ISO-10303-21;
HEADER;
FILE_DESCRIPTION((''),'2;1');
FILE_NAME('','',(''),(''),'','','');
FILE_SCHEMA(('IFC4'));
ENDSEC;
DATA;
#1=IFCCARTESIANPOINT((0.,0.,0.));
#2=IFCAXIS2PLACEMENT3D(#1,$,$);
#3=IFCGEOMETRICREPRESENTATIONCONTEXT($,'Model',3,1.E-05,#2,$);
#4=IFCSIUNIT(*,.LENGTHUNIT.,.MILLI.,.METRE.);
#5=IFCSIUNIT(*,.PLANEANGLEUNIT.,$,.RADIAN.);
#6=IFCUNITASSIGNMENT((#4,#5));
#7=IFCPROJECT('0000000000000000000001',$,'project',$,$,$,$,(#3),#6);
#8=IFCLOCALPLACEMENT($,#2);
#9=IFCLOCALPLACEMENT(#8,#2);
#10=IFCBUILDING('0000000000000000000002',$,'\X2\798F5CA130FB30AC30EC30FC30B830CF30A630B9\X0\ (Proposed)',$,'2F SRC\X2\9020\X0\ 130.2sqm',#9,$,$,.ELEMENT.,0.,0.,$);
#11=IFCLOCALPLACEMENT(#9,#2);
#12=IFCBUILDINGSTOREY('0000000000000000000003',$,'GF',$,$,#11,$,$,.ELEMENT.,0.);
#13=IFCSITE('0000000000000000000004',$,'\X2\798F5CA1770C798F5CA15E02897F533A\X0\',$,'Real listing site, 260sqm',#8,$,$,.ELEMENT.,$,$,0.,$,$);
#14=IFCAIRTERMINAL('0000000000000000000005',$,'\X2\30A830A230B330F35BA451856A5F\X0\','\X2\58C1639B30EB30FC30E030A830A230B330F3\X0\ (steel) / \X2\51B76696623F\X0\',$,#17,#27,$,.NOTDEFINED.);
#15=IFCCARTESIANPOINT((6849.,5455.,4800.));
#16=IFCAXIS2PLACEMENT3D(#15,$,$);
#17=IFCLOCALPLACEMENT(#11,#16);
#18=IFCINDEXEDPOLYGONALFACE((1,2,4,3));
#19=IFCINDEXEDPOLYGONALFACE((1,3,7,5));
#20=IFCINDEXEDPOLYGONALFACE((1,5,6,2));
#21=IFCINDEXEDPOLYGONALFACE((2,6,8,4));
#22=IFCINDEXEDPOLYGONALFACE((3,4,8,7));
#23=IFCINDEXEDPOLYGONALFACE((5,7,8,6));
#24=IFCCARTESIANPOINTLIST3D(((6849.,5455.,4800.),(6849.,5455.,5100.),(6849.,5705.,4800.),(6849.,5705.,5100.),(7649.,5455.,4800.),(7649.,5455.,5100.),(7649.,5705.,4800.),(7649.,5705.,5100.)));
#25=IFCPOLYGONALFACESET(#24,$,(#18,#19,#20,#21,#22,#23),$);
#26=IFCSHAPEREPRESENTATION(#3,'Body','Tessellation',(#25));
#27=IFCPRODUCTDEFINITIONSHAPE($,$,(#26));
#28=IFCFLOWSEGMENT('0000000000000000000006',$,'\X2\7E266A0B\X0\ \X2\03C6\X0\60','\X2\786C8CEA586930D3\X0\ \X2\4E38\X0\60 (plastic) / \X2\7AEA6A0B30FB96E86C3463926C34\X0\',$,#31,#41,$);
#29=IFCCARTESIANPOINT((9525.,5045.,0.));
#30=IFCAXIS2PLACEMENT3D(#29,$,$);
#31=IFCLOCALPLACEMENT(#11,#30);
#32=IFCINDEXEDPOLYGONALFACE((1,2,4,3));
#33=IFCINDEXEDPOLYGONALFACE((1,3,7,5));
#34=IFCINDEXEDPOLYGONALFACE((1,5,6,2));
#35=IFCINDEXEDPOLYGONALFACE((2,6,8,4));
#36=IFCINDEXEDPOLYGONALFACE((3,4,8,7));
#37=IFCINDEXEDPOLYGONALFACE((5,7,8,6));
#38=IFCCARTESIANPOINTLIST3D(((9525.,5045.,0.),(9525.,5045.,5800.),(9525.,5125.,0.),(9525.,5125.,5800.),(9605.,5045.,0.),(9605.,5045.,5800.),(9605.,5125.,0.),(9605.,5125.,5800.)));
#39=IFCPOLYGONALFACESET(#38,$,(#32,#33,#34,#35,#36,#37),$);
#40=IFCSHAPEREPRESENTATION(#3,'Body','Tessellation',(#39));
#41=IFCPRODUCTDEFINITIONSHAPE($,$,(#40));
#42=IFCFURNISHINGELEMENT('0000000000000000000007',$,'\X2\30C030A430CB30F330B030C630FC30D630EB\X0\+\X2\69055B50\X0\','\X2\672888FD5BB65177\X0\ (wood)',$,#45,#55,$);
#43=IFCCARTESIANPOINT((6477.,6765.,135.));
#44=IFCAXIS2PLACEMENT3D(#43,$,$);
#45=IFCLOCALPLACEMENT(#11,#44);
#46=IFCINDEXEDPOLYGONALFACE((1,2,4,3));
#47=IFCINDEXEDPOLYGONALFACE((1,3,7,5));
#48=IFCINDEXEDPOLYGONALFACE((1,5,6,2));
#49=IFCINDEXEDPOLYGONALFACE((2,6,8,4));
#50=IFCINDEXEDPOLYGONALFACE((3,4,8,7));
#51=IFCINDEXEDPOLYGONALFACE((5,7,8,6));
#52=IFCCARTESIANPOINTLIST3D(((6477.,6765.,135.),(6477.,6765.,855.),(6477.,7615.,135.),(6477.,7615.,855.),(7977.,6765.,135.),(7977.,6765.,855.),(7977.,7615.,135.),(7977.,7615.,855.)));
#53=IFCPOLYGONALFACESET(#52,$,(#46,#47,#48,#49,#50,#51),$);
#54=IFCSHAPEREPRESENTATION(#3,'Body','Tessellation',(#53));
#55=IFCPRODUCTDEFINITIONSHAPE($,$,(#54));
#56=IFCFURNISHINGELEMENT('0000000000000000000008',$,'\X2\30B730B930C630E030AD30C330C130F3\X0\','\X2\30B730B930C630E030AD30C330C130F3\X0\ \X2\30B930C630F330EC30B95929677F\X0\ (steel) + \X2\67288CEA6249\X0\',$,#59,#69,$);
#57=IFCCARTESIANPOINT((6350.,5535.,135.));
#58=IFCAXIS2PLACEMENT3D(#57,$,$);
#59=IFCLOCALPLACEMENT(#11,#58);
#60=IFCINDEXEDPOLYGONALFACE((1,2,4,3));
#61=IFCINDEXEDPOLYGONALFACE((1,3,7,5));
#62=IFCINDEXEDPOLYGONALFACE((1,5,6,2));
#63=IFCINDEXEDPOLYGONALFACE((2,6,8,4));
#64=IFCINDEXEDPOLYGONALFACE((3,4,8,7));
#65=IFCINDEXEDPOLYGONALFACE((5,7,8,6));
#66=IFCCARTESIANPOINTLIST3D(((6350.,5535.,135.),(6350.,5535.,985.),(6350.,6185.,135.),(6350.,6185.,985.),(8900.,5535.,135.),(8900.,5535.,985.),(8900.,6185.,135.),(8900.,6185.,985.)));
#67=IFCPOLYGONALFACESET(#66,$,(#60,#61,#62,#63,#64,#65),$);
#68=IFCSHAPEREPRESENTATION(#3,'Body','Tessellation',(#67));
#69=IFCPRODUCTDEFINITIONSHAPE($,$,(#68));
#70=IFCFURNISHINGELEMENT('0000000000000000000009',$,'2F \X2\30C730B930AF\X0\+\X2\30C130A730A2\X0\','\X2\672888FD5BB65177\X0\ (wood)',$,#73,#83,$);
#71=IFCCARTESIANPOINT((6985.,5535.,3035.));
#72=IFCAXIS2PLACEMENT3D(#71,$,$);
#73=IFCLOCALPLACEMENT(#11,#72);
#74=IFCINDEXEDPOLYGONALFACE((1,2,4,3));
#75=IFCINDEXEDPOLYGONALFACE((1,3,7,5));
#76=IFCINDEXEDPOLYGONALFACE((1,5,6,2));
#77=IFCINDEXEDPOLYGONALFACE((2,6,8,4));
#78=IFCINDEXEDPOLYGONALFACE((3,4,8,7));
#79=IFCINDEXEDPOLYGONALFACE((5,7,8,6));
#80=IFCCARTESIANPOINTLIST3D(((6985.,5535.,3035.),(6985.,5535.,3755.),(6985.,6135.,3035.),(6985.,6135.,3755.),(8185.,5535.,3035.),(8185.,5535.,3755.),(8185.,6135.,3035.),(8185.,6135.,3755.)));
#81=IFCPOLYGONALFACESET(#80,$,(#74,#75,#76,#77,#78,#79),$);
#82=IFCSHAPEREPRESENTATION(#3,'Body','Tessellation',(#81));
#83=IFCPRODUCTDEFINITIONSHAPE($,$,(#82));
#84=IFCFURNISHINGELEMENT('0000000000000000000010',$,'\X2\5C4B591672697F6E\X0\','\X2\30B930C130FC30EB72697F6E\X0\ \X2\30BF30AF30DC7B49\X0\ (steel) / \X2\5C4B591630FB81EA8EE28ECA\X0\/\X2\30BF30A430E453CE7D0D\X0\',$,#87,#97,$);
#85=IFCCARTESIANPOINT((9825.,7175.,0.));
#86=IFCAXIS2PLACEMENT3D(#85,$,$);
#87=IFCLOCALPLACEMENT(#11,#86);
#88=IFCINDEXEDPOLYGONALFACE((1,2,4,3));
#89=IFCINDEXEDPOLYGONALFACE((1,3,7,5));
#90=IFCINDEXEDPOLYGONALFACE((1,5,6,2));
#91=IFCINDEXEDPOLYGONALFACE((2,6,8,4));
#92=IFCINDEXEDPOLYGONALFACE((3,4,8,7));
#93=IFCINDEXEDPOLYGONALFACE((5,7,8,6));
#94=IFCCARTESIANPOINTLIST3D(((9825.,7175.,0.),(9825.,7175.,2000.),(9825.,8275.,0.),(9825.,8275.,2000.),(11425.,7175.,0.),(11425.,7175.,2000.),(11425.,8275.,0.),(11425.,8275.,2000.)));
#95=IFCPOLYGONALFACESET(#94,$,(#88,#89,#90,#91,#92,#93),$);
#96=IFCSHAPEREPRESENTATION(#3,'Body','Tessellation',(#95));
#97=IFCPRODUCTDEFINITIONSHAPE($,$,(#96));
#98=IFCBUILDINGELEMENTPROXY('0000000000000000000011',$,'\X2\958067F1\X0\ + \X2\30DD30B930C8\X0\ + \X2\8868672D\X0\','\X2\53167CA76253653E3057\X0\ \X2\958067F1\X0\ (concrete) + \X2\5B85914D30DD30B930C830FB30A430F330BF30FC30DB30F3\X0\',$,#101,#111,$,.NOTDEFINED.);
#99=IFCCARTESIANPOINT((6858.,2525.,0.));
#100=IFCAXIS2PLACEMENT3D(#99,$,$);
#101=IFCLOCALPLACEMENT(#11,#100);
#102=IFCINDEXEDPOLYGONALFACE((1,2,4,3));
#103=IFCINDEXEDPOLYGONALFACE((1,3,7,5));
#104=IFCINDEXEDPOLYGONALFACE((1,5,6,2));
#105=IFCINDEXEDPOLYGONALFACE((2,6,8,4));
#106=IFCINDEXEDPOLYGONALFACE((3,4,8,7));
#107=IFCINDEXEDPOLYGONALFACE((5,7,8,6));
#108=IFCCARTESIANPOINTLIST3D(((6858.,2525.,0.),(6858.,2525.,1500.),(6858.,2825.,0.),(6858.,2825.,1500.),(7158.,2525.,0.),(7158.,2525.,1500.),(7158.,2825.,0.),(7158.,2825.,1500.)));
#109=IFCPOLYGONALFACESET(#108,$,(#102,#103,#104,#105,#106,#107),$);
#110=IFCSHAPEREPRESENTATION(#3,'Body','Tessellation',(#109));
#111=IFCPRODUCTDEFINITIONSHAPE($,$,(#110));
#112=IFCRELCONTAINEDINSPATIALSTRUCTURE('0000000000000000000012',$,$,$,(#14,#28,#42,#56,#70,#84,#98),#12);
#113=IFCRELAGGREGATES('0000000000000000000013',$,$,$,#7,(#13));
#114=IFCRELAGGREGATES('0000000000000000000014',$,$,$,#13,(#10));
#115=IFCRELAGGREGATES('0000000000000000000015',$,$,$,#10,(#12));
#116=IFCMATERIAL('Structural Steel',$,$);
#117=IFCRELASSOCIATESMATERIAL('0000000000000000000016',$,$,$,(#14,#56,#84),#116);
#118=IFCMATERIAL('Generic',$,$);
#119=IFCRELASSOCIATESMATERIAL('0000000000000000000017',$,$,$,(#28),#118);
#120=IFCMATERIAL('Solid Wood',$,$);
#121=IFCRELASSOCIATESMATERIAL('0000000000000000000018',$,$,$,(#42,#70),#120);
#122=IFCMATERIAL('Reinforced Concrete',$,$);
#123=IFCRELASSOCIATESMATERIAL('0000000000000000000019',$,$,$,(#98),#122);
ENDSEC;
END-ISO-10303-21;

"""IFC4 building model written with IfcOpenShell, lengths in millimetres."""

from ifc_helpers import new_model, si_unit, frame, frame_2d, origin, place, context, project, spatial, rectangle, extrude, material, element, save


model = new_model("IFC4")

# Units and contexts
model_context = context("Model", 3, precision=1e-05, world=origin())
ifc_project = project(units=[si_unit("LENGTHUNIT", "METRE", prefix="MILLI"), si_unit("PLANEANGLEUNIT", "RADIAN")], contexts=[model_context])

# Site, building, storey
site_placement = place(None, origin())
site = spatial("IfcSite", under=ifc_project, at=site_placement, Name="福岡県福岡市西区", ObjectType="Real listing site, 260sqm", CompositionType="ELEMENT", RefElevation=0.0)
building_placement = place(site_placement, origin())
building = spatial("IfcBuilding", under=site, at=building_placement, Name="福岡・ガレージハウス (Proposed)", ObjectType="2F SRC造 130.2sqm", CompositionType="ELEMENT", ElevationOfRefHeight=0.0, ElevationOfTerrain=0.0)
storey_placement = place(building_placement, origin())
storey = spatial("IfcBuildingStorey", under=building, at=storey_placement, Name="GF", CompositionType="ELEMENT", Elevation=0.0)

# Shared definitions
ifc_material_1 = material(Name="Solid Wood")
ifc_material_2 = material(Name="Structural Steel")

# Shared definitions
ifc_material_3 = material(Name="Reinforced Concrete")

# Shared definitions
ifc_material_4 = material(Name="Generic")

# Air terminal
air_terminal_placement = place(storey_placement, frame((6849.0, 5455.0, 4800.0)))
element("IfcAirTerminal", 1, at=air_terminal_placement, inside=storey, material=ifc_material_2, Name="エアコン室内機", Description="壁掛ルームエアコン (steel) / 冷暖房", PredefinedType="NOTDEFINED", context=model_context, shape_type="SweptSolid", body=[
    extrude(rectangle(XDim=800.0, YDim=250.0, at=frame_2d((400.0, 125.0))), frame((6849.0, 5455.0, 4800.0)), (0.0, 0.0, 1.0), 300.0),
])

# Flow segment
flow_segment_placement = place(storey_placement, frame((9525.0, 5045.0, 0.0)))
element("IfcFlowSegment", 2, at=flow_segment_placement, inside=storey, material=ifc_material_4, Name="縦樋 φ60", Description="硬質塩ビ 丸60 (plastic) / 竪樋・雨水排水", context=model_context, shape_type="SweptSolid", body=[
    extrude(rectangle(XDim=80.0, YDim=80.0, at=frame_2d((40.0, 40.0))), frame((9525.0, 5045.0, 0.0)), (0.0, 0.0, 1.0), 5800.0),
])

# Furnishing elements
furnishing_1_placement = place(storey_placement, frame((6477.0, 6765.0, 135.0)))
element("IfcFurnishingElement", 3, at=furnishing_1_placement, inside=storey, material=ifc_material_1, Name="ダイニングテーブル+椅子", Description="木製家具 (wood)", context=model_context, shape_type="SweptSolid", body=[
    extrude(rectangle(XDim=1500.0, YDim=850.0, at=frame_2d((750.0, 425.0))), frame((6477.0, 6765.0, 135.0)), (0.0, 0.0, 1.0), 720.0),
])
furnishing_2_placement = place(storey_placement, frame((6350.0, 5535.0, 135.0)))
element("IfcFurnishingElement", 4, at=furnishing_2_placement, inside=storey, material=ifc_material_2, Name="システムキッチン", Description="システムキッチン ステンレス天板 (steel) + 木質扉", context=model_context, shape_type="SweptSolid", body=[
    extrude(rectangle(XDim=2550.0, YDim=650.0, at=frame_2d((1275.0, 325.0))), frame((6350.0, 5535.0, 135.0)), (0.0, 0.0, 1.0), 850.0),
])
furnishing_3_placement = place(storey_placement, frame((6985.0, 5535.0, 3035.0)))
element("IfcFurnishingElement", 5, at=furnishing_3_placement, inside=storey, material=ifc_material_1, Name="2F デスク+チェア", Description="木製家具 (wood)", context=model_context, shape_type="SweptSolid", body=[
    extrude(rectangle(XDim=1200.0, YDim=600.0, at=frame_2d((600.0, 300.0))), frame((6985.0, 5535.0, 3035.0)), (0.0, 0.0, 1.0), 720.0),
])
furnishing_4_placement = place(storey_placement, frame((9825.0, 7175.0, 0.0)))
element("IfcFurnishingElement", 6, at=furnishing_4_placement, inside=storey, material=ifc_material_2, Name="屋外物置", Description="スチール物置 タクボ等 (steel) / 屋外・自転車/タイヤ収納", context=model_context, shape_type="SweptSolid", body=[
    extrude(rectangle(XDim=1600.0, YDim=1100.0, at=frame_2d((800.0, 550.0))), frame((9825.0, 7175.0, 0.0)), (0.0, 0.0, 1.0), 2000.0),
])

# Building element proxy
proxy_placement = place(storey_placement, frame((6858.0, 2525.0, 0.0)))
element("IfcBuildingElementProxy", 7, at=proxy_placement, inside=storey, material=ifc_material_3, Name="門柱 + ポスト + 表札", Description="化粧打放し 門柱 (concrete) + 宅配ポスト・インターホン", PredefinedType="NOTDEFINED", context=model_context, shape_type="SweptSolid", body=[
    extrude(rectangle(XDim=300.0, YDim=300.0, at=frame_2d((150.0, 150.0))), frame((6858.0, 2525.0, 0.0)), (0.0, 0.0, 1.0), 1500.0),
])

save(model, "model.ifc")
